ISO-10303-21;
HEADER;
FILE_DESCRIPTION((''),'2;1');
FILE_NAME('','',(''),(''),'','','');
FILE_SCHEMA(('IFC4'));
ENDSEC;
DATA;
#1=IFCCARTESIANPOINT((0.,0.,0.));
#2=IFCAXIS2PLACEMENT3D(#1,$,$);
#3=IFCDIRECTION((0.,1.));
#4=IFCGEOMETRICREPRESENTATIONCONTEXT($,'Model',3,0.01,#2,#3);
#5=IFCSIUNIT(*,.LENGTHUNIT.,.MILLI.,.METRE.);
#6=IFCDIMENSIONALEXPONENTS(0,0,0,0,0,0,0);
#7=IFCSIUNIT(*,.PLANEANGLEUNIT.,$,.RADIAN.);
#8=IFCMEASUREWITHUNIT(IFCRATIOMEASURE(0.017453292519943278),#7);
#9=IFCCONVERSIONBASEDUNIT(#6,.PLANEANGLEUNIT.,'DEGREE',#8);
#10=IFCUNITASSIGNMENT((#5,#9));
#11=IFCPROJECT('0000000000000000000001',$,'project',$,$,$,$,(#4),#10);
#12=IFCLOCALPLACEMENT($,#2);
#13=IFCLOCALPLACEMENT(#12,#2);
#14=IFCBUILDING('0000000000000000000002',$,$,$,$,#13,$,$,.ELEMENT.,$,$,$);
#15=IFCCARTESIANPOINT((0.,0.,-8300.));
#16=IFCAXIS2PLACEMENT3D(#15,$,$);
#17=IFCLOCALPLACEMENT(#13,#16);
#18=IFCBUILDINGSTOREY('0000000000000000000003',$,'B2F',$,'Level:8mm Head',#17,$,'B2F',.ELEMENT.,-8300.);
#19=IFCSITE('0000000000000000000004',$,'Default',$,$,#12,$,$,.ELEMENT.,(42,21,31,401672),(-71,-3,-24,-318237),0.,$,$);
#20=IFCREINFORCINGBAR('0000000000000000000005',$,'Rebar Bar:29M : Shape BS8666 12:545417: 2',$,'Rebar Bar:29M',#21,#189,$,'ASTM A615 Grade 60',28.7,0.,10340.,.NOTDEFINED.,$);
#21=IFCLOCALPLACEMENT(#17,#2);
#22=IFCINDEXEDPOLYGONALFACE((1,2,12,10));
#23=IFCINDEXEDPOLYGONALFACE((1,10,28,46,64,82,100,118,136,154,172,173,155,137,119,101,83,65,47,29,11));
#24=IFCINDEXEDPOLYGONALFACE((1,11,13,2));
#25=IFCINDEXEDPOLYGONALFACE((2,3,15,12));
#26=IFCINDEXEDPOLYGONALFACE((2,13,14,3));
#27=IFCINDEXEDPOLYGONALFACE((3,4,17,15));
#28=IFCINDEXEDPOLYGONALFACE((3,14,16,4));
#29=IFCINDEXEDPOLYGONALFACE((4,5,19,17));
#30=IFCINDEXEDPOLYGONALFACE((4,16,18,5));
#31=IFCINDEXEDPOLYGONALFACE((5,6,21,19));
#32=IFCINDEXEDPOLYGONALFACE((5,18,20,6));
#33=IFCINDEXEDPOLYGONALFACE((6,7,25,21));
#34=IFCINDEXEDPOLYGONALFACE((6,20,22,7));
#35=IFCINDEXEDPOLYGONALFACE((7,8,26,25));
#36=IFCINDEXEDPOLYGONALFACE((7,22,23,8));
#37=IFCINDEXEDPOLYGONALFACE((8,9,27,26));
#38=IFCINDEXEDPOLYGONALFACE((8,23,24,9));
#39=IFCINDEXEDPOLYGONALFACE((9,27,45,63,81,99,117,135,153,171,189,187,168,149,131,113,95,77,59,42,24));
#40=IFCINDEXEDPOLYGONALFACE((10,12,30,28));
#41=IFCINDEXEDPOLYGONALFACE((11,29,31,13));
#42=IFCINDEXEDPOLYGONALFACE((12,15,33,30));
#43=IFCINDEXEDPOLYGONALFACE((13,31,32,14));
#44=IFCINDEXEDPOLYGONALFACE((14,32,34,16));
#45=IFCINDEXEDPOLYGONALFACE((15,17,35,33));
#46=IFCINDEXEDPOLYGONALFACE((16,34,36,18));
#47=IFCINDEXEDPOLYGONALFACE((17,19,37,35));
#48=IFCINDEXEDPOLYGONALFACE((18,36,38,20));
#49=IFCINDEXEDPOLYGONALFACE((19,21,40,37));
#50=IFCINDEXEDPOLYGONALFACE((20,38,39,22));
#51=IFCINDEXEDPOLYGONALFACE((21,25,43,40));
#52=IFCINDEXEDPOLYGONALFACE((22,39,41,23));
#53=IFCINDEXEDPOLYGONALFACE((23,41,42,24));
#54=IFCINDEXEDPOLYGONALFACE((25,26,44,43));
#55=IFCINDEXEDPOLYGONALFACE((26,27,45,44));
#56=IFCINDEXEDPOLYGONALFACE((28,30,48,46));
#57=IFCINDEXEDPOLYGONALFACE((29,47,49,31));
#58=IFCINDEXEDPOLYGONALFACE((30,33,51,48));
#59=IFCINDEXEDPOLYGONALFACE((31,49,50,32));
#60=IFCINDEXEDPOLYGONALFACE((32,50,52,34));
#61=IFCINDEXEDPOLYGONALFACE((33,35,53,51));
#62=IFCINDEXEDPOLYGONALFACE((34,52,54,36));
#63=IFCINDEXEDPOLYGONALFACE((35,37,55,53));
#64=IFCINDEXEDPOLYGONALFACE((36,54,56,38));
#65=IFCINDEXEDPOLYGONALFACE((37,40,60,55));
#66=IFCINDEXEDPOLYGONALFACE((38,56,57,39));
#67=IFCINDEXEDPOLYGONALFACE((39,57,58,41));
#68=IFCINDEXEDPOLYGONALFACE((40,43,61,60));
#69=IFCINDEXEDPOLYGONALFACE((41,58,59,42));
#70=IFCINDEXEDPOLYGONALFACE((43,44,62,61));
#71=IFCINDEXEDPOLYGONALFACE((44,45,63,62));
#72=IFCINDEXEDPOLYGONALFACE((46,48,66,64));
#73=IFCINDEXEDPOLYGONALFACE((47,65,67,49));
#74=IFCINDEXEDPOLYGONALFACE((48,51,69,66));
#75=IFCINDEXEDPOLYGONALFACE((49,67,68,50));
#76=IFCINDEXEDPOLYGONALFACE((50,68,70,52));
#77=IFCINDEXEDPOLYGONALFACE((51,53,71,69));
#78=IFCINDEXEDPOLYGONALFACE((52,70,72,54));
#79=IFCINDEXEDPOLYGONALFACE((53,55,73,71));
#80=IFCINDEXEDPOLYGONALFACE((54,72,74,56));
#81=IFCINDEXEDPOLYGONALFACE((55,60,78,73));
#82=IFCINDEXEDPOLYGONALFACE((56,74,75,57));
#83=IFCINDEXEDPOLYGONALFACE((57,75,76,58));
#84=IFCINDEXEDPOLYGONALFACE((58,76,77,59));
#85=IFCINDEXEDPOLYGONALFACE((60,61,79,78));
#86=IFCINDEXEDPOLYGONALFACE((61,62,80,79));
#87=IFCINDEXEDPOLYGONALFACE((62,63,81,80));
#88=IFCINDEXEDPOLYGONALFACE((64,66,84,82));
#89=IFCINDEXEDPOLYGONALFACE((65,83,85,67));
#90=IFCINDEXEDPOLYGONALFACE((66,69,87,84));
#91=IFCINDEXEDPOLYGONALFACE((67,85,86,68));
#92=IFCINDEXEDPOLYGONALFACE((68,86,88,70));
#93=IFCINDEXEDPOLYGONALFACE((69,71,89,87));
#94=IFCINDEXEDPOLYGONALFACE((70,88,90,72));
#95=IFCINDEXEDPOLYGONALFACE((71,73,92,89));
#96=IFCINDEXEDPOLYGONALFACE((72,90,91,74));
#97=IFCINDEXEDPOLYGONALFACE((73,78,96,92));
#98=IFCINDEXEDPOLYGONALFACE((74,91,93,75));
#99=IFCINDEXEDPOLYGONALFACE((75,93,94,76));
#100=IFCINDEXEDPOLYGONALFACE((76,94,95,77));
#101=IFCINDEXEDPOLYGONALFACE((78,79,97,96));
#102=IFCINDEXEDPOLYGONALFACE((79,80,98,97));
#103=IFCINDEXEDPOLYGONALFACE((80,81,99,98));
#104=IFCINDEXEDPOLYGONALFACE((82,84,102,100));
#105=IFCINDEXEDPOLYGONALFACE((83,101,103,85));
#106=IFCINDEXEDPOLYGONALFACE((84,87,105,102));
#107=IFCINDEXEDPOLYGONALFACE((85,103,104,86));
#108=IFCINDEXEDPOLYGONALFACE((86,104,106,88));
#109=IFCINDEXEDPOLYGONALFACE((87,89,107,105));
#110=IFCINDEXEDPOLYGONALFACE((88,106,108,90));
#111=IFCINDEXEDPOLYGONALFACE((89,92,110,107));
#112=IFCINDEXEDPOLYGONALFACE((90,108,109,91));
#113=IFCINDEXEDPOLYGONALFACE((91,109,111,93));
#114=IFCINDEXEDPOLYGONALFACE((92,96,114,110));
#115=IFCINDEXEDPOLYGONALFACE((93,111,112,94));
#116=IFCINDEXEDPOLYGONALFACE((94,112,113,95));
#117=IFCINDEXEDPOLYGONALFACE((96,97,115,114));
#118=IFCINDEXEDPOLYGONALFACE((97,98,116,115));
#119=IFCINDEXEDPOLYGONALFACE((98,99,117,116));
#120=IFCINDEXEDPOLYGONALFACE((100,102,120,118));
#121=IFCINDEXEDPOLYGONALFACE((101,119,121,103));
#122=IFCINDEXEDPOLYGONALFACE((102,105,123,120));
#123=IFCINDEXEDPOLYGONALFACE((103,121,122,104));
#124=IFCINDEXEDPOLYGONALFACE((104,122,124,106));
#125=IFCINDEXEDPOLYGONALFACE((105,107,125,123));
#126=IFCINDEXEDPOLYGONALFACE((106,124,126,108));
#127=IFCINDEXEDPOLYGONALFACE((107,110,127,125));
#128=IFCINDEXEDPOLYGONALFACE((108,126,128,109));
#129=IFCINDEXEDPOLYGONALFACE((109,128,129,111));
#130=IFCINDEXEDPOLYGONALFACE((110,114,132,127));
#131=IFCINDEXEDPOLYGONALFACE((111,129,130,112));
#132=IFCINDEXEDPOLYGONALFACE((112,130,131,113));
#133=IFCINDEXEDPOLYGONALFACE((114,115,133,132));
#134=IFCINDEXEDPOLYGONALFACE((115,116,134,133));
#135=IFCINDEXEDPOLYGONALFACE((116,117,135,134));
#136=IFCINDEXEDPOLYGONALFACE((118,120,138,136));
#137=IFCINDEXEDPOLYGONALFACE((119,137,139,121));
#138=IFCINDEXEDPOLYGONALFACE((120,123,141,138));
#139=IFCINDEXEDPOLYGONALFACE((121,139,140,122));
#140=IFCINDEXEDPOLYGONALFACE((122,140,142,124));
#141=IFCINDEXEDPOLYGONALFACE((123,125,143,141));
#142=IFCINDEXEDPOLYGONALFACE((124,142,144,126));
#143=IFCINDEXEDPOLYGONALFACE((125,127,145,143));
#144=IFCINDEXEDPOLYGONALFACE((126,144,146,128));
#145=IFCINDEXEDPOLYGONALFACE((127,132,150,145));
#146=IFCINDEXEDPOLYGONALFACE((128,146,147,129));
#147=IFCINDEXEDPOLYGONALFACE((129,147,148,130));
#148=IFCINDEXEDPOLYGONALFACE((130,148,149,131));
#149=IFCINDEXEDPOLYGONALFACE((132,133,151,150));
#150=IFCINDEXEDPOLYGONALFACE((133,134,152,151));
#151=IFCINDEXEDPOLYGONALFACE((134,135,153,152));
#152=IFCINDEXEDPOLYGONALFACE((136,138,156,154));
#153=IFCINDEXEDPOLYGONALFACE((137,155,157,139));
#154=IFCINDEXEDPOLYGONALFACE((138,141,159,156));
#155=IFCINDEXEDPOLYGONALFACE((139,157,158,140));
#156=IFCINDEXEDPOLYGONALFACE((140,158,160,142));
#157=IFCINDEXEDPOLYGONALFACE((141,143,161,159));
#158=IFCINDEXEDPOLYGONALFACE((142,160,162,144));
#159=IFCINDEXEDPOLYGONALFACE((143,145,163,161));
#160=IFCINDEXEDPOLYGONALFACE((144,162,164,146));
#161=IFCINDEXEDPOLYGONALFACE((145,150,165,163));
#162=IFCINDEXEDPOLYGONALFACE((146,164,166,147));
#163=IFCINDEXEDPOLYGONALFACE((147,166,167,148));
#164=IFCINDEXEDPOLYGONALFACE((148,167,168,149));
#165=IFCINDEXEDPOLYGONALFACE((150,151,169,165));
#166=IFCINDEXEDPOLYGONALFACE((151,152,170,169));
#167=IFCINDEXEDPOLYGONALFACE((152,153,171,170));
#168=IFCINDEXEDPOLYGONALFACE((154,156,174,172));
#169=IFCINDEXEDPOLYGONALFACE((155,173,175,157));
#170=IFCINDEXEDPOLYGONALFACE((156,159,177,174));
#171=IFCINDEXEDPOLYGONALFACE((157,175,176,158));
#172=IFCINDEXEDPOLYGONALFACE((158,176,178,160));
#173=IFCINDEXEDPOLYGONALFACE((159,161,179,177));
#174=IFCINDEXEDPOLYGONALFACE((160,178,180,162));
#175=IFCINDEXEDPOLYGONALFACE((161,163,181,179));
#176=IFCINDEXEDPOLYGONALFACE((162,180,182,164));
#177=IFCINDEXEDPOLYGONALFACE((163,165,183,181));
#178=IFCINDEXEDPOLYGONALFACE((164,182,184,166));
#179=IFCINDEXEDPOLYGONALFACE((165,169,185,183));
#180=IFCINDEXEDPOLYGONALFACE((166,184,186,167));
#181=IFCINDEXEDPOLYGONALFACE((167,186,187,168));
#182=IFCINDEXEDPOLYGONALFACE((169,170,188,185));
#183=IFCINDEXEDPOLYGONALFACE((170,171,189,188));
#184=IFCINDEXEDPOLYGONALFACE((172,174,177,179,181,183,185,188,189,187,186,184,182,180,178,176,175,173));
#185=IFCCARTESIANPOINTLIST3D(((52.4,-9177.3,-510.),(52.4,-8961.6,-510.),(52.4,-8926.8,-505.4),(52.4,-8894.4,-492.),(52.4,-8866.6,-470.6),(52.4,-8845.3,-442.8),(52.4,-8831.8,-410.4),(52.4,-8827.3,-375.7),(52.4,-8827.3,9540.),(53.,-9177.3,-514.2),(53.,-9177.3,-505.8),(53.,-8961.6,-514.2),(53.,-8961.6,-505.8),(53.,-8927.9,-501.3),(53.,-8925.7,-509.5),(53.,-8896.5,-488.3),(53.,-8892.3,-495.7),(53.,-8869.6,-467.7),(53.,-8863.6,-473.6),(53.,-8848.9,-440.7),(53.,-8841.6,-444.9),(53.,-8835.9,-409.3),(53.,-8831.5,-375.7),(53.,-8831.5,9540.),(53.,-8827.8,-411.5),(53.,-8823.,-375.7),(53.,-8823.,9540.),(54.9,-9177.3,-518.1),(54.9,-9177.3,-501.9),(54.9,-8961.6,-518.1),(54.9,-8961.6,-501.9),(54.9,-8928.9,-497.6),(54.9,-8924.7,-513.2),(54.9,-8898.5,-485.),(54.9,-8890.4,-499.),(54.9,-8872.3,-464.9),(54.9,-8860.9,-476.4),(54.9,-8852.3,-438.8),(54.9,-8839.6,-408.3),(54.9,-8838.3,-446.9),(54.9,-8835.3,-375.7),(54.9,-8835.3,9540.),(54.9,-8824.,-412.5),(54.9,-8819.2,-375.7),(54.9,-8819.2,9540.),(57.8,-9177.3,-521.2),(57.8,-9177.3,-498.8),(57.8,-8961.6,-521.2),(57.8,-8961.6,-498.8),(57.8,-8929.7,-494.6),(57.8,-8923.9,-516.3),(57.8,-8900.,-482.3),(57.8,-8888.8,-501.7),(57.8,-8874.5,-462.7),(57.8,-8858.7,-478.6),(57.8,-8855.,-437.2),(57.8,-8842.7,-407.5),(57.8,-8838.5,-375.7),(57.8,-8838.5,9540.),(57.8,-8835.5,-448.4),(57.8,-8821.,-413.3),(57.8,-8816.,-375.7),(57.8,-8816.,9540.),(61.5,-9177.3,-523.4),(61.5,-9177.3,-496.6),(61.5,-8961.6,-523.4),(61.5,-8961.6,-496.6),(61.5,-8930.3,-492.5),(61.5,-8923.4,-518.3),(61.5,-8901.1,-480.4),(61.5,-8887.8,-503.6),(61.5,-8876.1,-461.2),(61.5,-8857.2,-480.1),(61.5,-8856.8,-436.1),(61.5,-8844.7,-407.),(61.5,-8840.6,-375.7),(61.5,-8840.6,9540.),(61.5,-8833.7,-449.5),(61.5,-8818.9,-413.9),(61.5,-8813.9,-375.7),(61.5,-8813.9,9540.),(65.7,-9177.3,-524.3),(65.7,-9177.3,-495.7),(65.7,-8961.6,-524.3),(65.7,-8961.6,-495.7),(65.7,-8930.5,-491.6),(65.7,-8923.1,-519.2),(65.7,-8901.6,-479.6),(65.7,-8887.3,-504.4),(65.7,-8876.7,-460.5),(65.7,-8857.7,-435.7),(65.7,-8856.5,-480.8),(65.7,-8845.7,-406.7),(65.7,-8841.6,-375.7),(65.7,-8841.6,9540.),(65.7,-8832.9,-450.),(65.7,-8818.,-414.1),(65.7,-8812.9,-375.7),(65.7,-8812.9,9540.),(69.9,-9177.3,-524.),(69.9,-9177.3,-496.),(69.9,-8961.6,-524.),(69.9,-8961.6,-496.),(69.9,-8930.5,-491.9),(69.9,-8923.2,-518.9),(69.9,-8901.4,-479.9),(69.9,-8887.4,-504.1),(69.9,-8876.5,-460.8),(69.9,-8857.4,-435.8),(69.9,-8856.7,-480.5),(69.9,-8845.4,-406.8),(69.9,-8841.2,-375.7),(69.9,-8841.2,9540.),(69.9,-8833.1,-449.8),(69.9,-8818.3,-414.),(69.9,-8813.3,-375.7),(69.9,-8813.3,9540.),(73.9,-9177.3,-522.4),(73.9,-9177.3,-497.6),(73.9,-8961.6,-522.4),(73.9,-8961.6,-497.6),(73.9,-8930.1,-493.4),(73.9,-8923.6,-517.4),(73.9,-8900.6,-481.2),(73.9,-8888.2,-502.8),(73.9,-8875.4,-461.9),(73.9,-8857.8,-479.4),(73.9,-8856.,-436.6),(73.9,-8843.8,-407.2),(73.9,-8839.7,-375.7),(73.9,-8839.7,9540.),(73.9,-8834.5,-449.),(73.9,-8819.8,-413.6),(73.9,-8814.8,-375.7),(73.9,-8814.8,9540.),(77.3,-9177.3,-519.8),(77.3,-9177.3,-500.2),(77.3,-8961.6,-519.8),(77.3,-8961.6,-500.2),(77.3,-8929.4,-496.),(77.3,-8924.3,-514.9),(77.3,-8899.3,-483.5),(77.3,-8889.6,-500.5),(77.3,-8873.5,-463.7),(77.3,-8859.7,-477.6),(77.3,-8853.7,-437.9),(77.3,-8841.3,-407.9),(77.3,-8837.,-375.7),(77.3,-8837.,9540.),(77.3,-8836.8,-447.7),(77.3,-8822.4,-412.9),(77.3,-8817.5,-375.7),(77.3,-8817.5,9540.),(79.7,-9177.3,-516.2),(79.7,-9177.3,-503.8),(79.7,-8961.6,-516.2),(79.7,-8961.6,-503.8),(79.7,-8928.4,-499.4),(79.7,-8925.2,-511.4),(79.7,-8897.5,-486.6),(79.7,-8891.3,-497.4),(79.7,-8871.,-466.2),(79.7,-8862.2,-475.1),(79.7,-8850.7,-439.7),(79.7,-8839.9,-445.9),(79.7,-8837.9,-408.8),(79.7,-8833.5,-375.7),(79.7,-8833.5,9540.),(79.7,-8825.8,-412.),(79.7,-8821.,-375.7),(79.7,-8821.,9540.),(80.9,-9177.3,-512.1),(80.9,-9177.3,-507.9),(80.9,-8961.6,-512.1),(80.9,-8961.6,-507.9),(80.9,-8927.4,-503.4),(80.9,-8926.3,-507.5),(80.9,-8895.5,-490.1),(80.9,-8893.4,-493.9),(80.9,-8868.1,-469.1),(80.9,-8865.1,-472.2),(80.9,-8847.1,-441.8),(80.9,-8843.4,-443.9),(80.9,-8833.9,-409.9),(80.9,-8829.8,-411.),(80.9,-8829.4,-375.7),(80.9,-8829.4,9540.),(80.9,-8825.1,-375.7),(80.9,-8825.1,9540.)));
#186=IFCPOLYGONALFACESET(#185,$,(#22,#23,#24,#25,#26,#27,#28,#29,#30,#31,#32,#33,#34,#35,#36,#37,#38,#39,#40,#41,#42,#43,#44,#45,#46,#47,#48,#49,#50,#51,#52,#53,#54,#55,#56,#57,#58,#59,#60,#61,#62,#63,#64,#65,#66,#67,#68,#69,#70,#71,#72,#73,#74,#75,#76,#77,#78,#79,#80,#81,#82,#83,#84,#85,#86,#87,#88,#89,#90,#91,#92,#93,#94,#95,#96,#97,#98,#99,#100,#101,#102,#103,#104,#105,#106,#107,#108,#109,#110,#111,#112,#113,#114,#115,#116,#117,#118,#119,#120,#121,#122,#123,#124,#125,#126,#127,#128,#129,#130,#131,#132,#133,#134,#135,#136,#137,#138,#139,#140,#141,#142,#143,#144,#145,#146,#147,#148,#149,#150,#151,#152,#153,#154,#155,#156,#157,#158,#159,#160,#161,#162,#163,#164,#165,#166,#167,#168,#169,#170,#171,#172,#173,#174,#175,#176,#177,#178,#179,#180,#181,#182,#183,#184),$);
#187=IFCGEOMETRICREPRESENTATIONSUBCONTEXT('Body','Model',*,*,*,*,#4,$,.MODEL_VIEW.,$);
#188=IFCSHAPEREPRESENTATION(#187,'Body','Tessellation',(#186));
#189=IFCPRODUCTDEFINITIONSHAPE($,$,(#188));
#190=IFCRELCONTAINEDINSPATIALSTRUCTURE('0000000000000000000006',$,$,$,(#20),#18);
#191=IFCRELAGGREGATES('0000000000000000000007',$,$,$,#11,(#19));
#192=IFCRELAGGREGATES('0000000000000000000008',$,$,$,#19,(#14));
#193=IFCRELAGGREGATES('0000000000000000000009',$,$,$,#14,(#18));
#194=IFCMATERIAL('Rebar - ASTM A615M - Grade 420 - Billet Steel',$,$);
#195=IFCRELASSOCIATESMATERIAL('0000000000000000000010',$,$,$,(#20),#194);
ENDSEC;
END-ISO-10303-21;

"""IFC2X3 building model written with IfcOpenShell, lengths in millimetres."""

from ifc_helpers import new_model, entity, si_unit, converted_unit, direction, frame, origin, place, context, subcontext, project, spatial, material, element, save


model = new_model("IFC2X3")

# Units and contexts
model_context = context("Model", 3, precision=0.01, world=origin(), true_north=direction((0.0, 1.0)))
body_context = subcontext(model_context, "Body", "Model", "MODEL_VIEW")
ifc_project = project(units=[si_unit("LENGTHUNIT", "METRE", prefix="MILLI"), converted_unit("PLANEANGLEUNIT", "DEGREE", entity("IfcRatioMeasure", 0.017453292519943278), si_unit("PLANEANGLEUNIT", "RADIAN"), dimensions=[0, 0, 0, 0, 0, 0, 0])], contexts=[model_context])

# Site, building, storey
site_placement = place(None, origin())
site = spatial("IfcSite", under=ifc_project, at=site_placement, Name="Default", CompositionType="ELEMENT", RefLatitude=(42, 21, 31, 401672), RefLongitude=(-71, -3, -24, -318237), RefElevation=0.0)
building_placement = place(site_placement, origin())
building = spatial("IfcBuilding", under=site, at=building_placement, CompositionType="ELEMENT")
storey_placement = place(building_placement, frame((0.0, 0.0, -8300.0)))
storey = spatial("IfcBuildingStorey", under=building, at=storey_placement, Name="B2F", ObjectType="Level:8mm Head", LongName="B2F", CompositionType="ELEMENT", Elevation=-8300.0)

# Reinforcing bar
ifc_material_1 = material(Name="Rebar - ASTM A615M - Grade 420 - Billet Steel")
reinforcing_bar_1_placement = place(storey_placement, origin())
element("IfcReinforcingBar", 1, at=reinforcing_bar_1_placement, inside=storey, material=ifc_material_1, Name="Rebar Bar:29M : Shape BS8666 12:545417: 2", SteelGrade="ASTM A615 Grade 60", ObjectType="Rebar Bar:29M", BarLength=10340.0, BarRole="NOTDEFINED", CrossSectionArea=0.0, NominalDiameter=28.7, context=body_context, shape_type="AdvancedSweptSolid", body=[
    entity("IfcSweptDiskSolid", entity("IfcCompositeCurve", [entity("IfcCompositeCurveSegment", "CONTINUOUS", True, entity("IfcPolyline", [entity("IfcCartesianPoint", [66.7, -8827.3, 9540.0]), entity("IfcCartesianPoint", [66.7, -8827.3, -375.7])])), entity("IfcCompositeCurveSegment", "CONTINUOUS", True, entity("IfcTrimmedCurve", entity("IfcCircle", entity("IfcAxis2Placement3D", entity("IfcCartesianPoint", [66.7, -8961.6, -375.7]), entity("IfcDirection", [-1.0, 0.0, 0.0]), entity("IfcDirection", [0.0, 0.0, -1.0])), 134.3), [entity("IfcParameterValue", 270.0)], [entity("IfcParameterValue", 360.0)], True, "PARAMETER")), entity("IfcCompositeCurveSegment", "CONTINUOUS", True, entity("IfcPolyline", [entity("IfcCartesianPoint", [66.7, -8961.6, -510.0]), entity("IfcCartesianPoint", [66.7, -9177.3, -510.0])]))], False), 14.3, None, 0.0, 92.0),
])

save(model, "model.ifc")
